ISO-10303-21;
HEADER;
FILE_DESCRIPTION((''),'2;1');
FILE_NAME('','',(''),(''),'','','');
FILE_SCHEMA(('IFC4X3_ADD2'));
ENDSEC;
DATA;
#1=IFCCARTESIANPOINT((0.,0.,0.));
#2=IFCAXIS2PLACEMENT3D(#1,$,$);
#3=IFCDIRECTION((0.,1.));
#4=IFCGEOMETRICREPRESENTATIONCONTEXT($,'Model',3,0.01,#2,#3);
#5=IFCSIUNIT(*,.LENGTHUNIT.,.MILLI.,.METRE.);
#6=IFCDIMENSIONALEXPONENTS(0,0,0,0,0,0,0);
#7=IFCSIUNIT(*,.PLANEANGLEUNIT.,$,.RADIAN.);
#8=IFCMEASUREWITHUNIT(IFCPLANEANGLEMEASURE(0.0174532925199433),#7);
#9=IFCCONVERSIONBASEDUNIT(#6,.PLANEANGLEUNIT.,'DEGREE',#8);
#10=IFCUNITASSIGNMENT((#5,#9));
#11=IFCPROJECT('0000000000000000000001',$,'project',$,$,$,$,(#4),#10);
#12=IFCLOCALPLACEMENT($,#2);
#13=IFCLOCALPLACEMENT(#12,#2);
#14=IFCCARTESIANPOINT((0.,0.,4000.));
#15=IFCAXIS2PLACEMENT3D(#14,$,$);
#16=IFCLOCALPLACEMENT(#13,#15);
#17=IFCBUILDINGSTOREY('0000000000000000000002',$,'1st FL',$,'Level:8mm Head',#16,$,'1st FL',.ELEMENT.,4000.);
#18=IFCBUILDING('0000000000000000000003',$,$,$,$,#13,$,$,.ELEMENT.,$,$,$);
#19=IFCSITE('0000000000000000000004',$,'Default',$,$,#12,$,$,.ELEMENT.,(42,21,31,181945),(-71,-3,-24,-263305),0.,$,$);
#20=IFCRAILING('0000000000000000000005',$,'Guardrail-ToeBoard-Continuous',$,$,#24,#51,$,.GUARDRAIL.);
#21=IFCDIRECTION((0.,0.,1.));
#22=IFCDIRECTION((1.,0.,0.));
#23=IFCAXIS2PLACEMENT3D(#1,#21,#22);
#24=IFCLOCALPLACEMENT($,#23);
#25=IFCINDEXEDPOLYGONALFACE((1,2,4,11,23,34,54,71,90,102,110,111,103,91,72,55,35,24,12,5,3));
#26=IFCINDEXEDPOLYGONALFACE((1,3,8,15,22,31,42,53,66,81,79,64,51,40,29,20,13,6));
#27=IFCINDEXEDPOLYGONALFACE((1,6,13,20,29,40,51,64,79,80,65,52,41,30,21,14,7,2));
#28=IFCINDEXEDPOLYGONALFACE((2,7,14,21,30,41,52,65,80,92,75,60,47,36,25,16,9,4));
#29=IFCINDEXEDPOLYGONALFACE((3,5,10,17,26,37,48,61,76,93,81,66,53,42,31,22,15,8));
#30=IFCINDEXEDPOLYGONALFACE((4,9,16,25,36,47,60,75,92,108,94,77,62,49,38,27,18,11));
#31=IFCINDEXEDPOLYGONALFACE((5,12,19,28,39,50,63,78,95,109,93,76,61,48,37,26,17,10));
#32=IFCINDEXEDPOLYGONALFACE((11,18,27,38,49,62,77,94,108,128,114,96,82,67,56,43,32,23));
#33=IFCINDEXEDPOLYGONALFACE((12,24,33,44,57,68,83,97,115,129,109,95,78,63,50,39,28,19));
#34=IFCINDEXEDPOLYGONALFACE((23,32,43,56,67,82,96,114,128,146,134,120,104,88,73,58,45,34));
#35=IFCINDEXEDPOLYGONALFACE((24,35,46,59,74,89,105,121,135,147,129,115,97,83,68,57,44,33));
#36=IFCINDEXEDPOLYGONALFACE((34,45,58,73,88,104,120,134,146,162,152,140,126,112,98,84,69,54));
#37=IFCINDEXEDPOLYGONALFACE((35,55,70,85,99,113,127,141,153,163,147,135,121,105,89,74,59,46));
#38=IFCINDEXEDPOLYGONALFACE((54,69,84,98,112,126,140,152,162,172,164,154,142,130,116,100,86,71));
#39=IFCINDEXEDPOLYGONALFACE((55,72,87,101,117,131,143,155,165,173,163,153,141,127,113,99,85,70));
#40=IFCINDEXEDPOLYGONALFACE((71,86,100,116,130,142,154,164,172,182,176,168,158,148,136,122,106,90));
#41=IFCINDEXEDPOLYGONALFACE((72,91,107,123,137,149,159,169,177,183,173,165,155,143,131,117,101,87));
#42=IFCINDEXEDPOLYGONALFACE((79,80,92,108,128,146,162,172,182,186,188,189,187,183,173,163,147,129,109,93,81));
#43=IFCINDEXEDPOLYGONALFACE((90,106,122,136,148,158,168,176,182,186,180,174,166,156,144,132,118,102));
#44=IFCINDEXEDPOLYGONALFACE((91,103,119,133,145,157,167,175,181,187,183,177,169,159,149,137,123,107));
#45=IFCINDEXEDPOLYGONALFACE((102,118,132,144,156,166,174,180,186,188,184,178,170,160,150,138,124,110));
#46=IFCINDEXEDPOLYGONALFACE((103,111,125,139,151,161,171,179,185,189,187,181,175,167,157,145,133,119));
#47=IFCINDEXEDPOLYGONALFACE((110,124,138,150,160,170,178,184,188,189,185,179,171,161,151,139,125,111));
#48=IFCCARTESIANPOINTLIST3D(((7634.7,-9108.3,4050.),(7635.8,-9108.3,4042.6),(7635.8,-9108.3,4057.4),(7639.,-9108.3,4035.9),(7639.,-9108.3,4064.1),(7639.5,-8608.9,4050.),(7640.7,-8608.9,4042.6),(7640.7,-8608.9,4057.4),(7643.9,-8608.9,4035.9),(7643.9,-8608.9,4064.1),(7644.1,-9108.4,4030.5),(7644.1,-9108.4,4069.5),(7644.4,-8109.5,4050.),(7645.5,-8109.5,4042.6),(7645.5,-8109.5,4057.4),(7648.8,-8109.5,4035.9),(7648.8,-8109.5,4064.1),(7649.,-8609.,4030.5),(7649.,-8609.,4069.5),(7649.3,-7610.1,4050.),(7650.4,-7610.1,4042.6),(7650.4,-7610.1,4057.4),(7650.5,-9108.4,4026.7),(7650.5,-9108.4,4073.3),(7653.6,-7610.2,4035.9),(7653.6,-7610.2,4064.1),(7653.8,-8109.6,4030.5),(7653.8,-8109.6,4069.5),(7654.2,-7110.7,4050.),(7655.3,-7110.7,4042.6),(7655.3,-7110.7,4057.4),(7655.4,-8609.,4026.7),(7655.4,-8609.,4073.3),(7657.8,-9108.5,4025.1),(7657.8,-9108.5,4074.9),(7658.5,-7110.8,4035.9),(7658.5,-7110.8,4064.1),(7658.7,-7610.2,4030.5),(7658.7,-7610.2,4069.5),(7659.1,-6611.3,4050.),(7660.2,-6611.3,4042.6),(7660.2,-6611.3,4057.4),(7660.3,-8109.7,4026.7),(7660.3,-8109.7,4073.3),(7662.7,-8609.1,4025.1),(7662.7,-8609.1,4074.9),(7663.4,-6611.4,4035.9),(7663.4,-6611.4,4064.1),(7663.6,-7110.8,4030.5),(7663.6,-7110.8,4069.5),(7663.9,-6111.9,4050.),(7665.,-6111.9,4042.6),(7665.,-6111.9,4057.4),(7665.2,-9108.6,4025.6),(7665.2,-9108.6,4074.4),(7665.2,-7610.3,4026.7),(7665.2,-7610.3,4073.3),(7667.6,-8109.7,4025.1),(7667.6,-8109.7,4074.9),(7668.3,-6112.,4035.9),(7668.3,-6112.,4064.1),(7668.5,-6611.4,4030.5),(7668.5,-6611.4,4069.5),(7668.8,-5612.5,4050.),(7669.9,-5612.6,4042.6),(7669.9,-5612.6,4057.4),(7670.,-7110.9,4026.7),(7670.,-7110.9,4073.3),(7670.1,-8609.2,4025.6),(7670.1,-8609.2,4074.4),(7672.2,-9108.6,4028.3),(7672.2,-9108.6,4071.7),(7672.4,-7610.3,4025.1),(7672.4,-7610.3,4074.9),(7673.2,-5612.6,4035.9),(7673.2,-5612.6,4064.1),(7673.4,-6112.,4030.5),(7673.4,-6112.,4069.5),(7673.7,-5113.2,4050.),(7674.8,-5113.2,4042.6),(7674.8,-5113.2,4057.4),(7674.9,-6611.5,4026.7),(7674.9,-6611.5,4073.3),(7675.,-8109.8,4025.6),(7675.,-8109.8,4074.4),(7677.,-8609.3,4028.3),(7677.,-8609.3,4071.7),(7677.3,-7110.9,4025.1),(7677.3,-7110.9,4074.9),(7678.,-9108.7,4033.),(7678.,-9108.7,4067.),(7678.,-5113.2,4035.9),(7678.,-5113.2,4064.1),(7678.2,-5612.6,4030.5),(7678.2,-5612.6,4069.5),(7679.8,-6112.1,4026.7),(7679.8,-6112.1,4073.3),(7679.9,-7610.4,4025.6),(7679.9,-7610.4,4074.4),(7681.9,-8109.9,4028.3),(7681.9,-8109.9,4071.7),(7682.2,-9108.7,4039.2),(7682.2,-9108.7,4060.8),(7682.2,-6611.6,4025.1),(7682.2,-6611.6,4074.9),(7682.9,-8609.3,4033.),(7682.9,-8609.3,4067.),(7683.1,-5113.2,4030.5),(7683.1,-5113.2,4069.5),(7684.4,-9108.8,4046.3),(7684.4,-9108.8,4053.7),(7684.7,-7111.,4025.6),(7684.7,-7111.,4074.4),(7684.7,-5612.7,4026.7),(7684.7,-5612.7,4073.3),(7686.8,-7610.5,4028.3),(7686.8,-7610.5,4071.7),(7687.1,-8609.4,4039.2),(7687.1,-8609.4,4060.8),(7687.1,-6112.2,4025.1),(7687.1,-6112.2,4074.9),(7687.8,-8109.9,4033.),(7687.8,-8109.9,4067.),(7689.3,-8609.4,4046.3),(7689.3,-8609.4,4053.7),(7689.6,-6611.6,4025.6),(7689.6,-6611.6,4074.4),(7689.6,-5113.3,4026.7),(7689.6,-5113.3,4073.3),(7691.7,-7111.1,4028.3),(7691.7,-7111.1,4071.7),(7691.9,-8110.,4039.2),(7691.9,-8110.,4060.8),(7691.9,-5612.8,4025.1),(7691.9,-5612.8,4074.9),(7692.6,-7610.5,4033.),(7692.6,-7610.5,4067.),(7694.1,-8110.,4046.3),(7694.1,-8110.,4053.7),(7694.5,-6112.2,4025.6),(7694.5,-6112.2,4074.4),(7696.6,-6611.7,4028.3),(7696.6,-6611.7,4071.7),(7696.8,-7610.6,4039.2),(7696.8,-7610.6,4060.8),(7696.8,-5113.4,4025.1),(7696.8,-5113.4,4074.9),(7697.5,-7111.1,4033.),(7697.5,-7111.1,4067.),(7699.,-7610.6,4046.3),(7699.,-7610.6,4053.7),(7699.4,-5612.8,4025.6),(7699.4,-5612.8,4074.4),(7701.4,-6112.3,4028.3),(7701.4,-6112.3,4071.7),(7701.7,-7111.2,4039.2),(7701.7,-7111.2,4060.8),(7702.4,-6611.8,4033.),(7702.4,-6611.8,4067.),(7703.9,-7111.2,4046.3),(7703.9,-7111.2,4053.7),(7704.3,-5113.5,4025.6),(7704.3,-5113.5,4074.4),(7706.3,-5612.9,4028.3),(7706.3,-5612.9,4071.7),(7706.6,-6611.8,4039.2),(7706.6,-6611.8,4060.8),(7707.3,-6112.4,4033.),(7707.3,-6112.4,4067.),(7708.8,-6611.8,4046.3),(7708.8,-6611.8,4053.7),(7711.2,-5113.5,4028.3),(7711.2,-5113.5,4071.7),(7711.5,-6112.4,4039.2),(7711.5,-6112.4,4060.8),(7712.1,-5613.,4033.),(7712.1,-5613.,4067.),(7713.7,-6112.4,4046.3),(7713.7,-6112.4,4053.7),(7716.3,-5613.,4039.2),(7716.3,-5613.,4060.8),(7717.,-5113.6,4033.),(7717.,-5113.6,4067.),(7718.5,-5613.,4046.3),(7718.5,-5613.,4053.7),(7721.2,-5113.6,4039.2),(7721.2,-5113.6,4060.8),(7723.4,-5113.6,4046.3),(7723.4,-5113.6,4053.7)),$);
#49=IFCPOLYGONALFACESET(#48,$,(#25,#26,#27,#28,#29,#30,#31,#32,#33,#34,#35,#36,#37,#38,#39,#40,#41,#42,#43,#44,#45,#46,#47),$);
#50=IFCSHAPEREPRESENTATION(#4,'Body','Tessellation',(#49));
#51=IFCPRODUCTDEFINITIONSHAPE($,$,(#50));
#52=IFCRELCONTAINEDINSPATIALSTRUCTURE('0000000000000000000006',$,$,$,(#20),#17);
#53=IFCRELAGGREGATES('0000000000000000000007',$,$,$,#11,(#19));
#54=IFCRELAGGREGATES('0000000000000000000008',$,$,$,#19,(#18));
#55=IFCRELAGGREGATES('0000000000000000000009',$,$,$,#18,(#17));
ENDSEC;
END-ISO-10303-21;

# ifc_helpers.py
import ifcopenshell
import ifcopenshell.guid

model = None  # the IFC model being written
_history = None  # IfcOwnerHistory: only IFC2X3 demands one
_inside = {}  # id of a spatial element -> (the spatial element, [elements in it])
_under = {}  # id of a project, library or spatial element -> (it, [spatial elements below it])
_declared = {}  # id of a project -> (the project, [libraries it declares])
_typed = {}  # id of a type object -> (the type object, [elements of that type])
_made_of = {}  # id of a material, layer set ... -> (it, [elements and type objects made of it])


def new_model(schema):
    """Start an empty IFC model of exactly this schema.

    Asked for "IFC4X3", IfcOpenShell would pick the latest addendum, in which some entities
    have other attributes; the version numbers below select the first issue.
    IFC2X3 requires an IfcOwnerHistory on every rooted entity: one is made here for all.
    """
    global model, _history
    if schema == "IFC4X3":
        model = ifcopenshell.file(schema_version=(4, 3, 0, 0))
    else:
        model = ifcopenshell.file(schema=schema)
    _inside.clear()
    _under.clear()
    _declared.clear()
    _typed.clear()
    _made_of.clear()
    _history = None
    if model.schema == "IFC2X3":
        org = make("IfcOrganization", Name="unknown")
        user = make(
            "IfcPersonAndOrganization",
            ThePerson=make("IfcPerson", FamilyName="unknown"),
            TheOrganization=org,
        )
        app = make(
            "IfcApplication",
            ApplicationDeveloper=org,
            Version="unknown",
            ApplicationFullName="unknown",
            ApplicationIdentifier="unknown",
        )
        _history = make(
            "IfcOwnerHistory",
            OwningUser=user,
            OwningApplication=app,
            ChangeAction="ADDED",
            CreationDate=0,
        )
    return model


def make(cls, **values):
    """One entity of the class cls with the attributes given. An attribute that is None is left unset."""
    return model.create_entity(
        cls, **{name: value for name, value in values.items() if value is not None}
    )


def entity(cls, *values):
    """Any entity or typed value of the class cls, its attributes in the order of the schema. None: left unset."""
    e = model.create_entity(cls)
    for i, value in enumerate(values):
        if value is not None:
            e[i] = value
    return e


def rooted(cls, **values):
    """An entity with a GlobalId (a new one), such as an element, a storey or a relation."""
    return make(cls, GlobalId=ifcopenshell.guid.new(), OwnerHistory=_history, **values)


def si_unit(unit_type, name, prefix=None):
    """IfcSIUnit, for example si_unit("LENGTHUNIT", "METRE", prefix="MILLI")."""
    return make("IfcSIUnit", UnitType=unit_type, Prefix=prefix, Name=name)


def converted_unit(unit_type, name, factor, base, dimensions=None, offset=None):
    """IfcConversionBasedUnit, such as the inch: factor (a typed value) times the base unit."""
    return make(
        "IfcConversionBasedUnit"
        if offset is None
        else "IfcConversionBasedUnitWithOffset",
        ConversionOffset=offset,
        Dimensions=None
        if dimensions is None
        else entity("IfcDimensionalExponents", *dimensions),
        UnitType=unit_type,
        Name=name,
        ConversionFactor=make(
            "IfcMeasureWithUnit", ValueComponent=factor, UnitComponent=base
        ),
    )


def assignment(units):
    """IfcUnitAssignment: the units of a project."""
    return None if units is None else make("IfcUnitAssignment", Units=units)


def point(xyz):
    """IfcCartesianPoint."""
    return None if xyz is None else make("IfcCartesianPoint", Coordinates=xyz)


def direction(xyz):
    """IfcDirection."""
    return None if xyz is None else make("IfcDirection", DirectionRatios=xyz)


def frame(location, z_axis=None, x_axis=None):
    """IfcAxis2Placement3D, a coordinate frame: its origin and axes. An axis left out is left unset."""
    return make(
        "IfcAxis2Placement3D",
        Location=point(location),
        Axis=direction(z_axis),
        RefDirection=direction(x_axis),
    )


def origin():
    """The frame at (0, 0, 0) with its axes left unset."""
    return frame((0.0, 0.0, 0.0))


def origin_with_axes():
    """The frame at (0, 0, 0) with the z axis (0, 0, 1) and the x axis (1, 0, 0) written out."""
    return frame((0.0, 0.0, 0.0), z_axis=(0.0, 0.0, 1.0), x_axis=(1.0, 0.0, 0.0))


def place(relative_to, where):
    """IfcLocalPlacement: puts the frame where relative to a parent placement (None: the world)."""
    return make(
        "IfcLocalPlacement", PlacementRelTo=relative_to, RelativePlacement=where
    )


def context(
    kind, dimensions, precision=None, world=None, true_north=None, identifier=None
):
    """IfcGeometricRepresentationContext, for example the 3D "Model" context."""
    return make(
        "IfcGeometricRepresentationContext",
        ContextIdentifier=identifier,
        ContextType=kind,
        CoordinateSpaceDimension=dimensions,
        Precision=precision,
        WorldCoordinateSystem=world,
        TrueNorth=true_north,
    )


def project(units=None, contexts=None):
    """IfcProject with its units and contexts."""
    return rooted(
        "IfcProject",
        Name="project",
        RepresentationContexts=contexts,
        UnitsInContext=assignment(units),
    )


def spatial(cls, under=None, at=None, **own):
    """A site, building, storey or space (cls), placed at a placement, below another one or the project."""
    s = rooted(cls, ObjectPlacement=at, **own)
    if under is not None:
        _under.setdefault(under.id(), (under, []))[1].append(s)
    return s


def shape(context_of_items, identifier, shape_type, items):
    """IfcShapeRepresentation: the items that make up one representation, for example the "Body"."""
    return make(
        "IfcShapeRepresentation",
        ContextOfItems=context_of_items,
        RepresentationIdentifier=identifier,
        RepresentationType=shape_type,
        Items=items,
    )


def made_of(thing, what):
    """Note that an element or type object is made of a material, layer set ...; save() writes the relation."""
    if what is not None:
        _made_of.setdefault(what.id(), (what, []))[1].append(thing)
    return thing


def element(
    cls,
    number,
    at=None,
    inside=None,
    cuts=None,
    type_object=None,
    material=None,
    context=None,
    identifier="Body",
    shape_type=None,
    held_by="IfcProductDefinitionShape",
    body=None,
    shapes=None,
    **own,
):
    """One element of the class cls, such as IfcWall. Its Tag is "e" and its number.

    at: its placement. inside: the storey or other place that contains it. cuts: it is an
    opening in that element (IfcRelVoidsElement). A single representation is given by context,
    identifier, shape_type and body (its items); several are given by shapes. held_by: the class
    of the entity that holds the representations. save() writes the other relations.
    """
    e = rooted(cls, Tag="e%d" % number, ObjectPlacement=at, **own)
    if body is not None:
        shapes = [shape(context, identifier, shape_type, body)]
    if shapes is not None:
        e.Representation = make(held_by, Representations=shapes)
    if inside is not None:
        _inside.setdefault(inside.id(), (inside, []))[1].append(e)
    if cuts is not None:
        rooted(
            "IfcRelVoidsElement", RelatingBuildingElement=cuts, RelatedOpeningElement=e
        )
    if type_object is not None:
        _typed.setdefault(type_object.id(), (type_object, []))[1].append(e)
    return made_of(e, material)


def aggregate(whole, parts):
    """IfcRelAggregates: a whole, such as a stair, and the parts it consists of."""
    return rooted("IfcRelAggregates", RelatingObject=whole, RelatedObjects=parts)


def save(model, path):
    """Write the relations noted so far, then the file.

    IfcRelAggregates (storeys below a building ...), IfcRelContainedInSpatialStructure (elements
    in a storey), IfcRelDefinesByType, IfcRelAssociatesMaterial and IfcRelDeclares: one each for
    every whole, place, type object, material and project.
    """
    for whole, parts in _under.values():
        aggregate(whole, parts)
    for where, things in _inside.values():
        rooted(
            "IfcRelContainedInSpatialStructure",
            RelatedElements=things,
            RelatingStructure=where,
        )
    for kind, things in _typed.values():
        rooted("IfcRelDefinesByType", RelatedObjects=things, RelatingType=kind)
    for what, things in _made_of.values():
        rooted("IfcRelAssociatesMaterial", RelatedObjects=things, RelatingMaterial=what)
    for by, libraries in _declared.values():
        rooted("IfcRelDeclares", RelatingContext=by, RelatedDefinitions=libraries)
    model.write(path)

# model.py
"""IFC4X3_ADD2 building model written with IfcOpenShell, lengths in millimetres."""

from ifc_helpers import new_model, entity, si_unit, converted_unit, direction, frame, origin, origin_with_axes, place, context, project, spatial, element, save


model = new_model("IFC4X3_ADD2")

# Units and contexts
model_context = context("Model", 3, precision=0.01, world=origin(), true_north=direction((0.0, 1.0)))
ifc_project = project(units=[si_unit("LENGTHUNIT", "METRE", prefix="MILLI"), converted_unit("PLANEANGLEUNIT", "DEGREE", entity("IfcPlaneAngleMeasure", 0.0174532925199433), si_unit("PLANEANGLEUNIT", "RADIAN"), dimensions=[0, 0, 0, 0, 0, 0, 0])], contexts=[model_context])

# Site, building, storey
site_placement = place(None, origin())
site = spatial("IfcSite", under=ifc_project, at=site_placement, Name="Default", CompositionType="ELEMENT", RefLatitude=(42, 21, 31, 181945), RefLongitude=(-71, -3, -24, -263305), RefElevation=0.0)
building_placement = place(site_placement, origin())
building = spatial("IfcBuilding", under=site, at=building_placement, CompositionType="ELEMENT")
storey_placement = place(building_placement, frame((0.0, 0.0, 4000.0)))
storey = spatial("IfcBuildingStorey", under=building, at=storey_placement, Name="1st FL", ObjectType="Level:8mm Head", LongName="1st FL", CompositionType="ELEMENT", Elevation=4000.0)

# Railing
railing_1_placement = place(None, origin_with_axes())
element("IfcRailing", 1, at=railing_1_placement, inside=storey, Name="Guardrail-ToeBoard-Continuous", PredefinedType="GUARDRAIL", context=model_context, shape_type="SweptSolid", body=[
    entity("IfcSweptDiskSolid", entity("IfcPolyline", [entity("IfcCartesianPoint", [7698.7, -5113.4, 4050.0]), entity("IfcCartesianPoint", [7693.8, -5612.8, 4050.0]), entity("IfcCartesianPoint", [7688.9, -6112.2, 4050.0]), entity("IfcCartesianPoint", [7684.1, -6611.6, 4050.0]), entity("IfcCartesianPoint", [7679.2, -7111.0, 4050.0]), entity("IfcCartesianPoint", [7674.3, -7610.4, 4050.0]), entity("IfcCartesianPoint", [7669.4, -8109.7, 4050.0]), entity("IfcCartesianPoint", [7664.5, -8609.1, 4050.0]), entity("IfcCartesianPoint", [7659.7, -9108.5, 4050.0])]), 25.0),
])

save(model, "model.ifc")
